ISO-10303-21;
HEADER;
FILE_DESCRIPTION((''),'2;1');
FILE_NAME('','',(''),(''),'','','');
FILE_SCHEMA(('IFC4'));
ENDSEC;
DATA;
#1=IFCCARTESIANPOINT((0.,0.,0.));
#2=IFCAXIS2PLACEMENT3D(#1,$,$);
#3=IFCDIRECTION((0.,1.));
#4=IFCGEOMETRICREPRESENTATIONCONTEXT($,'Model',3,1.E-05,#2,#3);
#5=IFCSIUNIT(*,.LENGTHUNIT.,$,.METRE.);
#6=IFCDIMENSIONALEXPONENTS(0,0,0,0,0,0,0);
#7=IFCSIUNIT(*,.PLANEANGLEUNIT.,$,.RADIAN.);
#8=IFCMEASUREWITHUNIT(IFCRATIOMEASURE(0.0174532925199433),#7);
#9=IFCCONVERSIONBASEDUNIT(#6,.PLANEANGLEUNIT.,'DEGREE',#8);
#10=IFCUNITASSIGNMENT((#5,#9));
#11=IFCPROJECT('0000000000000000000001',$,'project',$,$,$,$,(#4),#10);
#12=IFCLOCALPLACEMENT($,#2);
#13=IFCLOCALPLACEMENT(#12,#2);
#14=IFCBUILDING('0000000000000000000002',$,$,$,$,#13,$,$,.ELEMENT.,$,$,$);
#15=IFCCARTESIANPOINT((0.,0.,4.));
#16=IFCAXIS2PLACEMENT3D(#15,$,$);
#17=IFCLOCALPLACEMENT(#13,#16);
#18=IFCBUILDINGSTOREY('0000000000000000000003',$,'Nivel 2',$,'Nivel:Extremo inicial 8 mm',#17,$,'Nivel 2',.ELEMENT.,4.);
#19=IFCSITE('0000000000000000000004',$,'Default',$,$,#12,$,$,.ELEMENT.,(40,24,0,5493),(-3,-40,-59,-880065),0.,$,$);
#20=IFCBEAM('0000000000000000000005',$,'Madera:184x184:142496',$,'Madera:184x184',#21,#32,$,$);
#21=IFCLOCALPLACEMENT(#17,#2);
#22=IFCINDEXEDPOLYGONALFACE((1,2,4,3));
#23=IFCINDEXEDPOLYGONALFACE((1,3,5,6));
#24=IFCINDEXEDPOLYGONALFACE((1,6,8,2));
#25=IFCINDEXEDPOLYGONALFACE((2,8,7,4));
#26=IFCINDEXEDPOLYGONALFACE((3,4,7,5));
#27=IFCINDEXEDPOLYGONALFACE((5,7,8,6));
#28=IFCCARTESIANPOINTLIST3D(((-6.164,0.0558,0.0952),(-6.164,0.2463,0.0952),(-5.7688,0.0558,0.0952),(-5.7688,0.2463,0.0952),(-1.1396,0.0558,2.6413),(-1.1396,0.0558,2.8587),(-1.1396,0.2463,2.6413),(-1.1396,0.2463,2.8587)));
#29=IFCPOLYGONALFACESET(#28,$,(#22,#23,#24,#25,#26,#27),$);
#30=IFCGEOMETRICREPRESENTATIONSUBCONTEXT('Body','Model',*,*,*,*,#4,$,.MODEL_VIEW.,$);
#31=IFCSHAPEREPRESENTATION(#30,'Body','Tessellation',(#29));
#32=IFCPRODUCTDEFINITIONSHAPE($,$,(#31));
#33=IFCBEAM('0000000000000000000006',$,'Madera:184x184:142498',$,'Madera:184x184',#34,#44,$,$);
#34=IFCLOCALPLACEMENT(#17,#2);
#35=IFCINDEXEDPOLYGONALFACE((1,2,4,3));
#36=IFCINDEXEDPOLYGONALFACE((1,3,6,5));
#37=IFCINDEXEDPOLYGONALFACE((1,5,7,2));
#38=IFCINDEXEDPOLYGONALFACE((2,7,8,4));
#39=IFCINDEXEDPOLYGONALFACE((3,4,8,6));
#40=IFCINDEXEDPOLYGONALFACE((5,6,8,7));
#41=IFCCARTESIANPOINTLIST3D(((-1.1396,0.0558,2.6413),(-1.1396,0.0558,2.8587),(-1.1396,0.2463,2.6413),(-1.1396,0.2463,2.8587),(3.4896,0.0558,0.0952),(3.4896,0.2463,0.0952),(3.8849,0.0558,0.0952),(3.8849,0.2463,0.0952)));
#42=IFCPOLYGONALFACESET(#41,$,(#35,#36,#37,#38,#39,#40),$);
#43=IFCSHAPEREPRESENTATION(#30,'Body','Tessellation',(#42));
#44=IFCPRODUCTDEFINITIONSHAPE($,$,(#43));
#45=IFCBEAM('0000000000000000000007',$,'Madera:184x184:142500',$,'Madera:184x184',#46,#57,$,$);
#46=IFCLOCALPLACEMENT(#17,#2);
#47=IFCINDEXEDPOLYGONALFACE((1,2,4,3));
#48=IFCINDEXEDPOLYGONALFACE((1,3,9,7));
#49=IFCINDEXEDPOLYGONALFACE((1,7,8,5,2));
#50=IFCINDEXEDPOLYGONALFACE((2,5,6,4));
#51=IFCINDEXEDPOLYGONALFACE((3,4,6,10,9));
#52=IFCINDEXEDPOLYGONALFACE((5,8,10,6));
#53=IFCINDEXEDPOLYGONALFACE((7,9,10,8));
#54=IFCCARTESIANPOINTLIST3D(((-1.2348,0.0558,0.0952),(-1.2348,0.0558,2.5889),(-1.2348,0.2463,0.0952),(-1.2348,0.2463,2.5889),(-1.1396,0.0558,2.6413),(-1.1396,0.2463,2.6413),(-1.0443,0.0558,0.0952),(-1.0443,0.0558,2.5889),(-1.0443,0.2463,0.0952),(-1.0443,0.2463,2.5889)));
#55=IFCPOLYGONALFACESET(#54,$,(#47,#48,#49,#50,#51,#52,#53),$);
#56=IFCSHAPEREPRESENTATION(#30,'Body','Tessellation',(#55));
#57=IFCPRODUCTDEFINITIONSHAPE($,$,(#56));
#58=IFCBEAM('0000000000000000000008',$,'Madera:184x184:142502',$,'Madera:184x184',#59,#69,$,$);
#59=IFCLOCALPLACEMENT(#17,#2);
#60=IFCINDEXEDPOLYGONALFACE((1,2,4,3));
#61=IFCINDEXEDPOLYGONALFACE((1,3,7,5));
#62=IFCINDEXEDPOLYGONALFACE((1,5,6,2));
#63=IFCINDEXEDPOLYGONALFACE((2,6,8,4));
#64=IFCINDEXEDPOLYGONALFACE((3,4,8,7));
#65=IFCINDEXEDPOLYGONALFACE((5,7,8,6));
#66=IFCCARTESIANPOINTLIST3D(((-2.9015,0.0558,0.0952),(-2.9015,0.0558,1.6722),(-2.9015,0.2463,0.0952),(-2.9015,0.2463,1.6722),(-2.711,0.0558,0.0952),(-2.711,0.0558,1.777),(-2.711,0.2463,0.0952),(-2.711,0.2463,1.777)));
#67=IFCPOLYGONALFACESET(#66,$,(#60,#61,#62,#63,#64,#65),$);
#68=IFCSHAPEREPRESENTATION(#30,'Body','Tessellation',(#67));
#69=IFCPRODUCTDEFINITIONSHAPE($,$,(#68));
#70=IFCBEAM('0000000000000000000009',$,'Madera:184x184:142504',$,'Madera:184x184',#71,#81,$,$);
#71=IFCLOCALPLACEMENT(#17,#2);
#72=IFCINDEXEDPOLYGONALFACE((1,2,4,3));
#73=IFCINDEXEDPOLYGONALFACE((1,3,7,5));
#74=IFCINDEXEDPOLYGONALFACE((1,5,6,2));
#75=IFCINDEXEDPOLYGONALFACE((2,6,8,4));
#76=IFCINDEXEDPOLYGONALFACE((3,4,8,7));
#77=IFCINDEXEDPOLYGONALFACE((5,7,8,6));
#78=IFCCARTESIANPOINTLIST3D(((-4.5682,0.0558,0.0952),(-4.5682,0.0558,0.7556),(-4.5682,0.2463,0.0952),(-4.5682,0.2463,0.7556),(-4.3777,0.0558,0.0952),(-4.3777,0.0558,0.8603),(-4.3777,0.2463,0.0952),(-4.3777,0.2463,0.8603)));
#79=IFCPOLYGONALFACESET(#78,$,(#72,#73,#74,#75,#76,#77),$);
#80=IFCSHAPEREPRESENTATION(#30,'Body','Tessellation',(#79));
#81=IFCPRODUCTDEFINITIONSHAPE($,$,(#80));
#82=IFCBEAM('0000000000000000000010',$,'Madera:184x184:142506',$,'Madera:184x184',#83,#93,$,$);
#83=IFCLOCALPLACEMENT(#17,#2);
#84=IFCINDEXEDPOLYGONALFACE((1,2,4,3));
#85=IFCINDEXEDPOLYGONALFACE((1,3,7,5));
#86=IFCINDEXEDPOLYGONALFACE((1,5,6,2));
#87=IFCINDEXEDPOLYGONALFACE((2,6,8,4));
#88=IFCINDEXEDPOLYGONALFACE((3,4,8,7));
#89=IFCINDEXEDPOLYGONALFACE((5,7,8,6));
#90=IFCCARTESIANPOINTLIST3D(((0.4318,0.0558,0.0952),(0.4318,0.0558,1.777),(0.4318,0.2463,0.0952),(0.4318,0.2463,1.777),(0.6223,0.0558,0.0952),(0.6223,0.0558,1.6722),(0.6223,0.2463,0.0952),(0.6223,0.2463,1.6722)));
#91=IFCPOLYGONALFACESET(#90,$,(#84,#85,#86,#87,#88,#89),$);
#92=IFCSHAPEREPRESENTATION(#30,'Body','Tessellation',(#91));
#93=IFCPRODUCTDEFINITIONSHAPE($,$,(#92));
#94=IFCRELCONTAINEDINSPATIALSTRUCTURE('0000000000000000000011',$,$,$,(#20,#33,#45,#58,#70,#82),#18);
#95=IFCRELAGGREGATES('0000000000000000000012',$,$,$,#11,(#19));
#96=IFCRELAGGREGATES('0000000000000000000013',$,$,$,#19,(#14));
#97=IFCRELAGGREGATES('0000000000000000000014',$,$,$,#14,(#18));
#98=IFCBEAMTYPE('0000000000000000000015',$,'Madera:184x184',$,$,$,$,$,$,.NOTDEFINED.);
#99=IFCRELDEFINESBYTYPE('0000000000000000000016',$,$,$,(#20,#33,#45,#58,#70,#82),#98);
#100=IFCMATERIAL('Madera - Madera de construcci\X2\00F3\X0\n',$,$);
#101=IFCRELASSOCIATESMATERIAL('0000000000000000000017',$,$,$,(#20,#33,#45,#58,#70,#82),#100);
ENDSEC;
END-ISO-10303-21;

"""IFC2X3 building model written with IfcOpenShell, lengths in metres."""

from ifc_helpers import new_model, entity, si_unit, converted_unit, direction, frame, frame_2d, origin, origin_2d_with_axis, place, context, subcontext, project, spatial, rectangle, extrude, clip, halfspace, material, type_object, element, save


model = new_model("IFC2X3")

# Units and contexts
model_context = context("Model", 3, precision=1e-05, world=origin(), true_north=direction((0.0, 1.0)))
body_context = subcontext(model_context, "Body", "Model", "MODEL_VIEW")
ifc_project = project(units=[si_unit("LENGTHUNIT", "METRE"), converted_unit("PLANEANGLEUNIT", "DEGREE", entity("IfcRatioMeasure", 0.0174532925199433), si_unit("PLANEANGLEUNIT", "RADIAN"), dimensions=[0, 0, 0, 0, 0, 0, 0])], contexts=[model_context])

# Site, building, storey
site_placement = place(None, origin())
site = spatial("IfcSite", under=ifc_project, at=site_placement, Name="Default", CompositionType="ELEMENT", RefLatitude=(40, 24, 0, 5493), RefLongitude=(-3, -40, -59, -880065), RefElevation=0.0)
building_placement = place(site_placement, origin())
building = spatial("IfcBuilding", under=site, at=building_placement, CompositionType="ELEMENT")
storey_placement = place(building_placement, frame((0.0, 0.0, 4.0)))
storey = spatial("IfcBuildingStorey", under=building, at=storey_placement, Name="Nivel 2", ObjectType="Nivel:Extremo inicial 8 mm", LongName="Nivel 2", CompositionType="ELEMENT", Elevation=4.0)

# Beams
ifc_material = material(Name="Madera - Madera de construcción")
beam_type = type_object("IfcBeamType", Name="Madera:184x184", PredefinedType="NOTDEFINED")
beam_1_placement = place(storey_placement, frame((-6.1396, 0.1511, 0.0), z_axis=(-0.481919, 0.0, 0.876216), x_axis=(0.876216, 0.0, 0.481919)))
element("IfcBeam", 1, at=beam_1_placement, inside=storey, type_object=beam_type, material=ifc_material, Name="Madera:184x184:142496", ObjectType="Madera:184x184", context=body_context, shape_type="Clipping", body=[
    clip(clip(extrude(rectangle(XDim=0.1905, YDim=0.1905, at=frame_2d((0.0, 0.0), x_axis=(1.0, 0.0))), frame((0.0245, 0.0, 0.0), z_axis=(1.0, 0.0, 0.0), x_axis=(0.0, 0.0, -1.0)), (0.0, 0.0, 1.0), 5.7343), halfspace(frame((-0.0919, -0.0953, 0.1593), z_axis=(-0.481919, 0.0, -0.876216), x_axis=(0.876216, 0.0, -0.481919)), False)), halfspace(frame((5.7587, 0.0, 0.0952), z_axis=(0.876216, 0.0, -0.481919), x_axis=(0.0, -1.0, 0.0)), False)),
])
beam_2_placement = place(storey_placement, frame((-1.1396, 0.1511, 2.75), z_axis=(0.481919, 0.0, 0.876216), x_axis=(0.876216, 0.0, -0.481919)))
element("IfcBeam", 2, at=beam_2_placement, inside=storey, type_object=beam_type, material=ifc_material, Name="Madera:184x184:142498", ObjectType="Madera:184x184", context=body_context, shape_type="Clipping", body=[
    clip(clip(extrude(rectangle(XDim=0.1905, YDim=0.1905, at=frame_2d((0.0, 0.0), x_axis=(1.0, 0.0))), frame((-0.0524, 0.0, 0.0), z_axis=(1.0, 0.0, 0.0), x_axis=(0.0, 0.0, -1.0)), (0.0, 0.0, 1.0), 5.7343), halfspace(frame((-3.2395, -0.0953, -4.8115), z_axis=(0.481919, 0.0, -0.876216), x_axis=(0.876216, 0.0, 0.481919)), False)), halfspace(frame((-0.0524, 0.0, 0.0952), z_axis=(-0.876216, 0.0, -0.481919), x_axis=(0.0, 1.0, 0.0)), False)),
])
beam_3_placement = place(storey_placement, frame((-1.1396, 0.1511, 0.0), z_axis=(1.0, 0.0, 0.0), x_axis=(0.0, 0.0, 1.0)))
element("IfcBeam", 3, at=beam_3_placement, inside=storey, type_object=beam_type, material=ifc_material, Name="Madera:184x184:142500", ObjectType="Madera:184x184", context=body_context, shape_type="Clipping", body=[
    clip(clip(extrude(rectangle(XDim=0.1905, YDim=0.1905, at=frame_2d((0.0, 0.0), x_axis=(1.0, 0.0))), frame((0.0952, 0.0, 0.0), z_axis=(1.0, 0.0, 0.0), x_axis=(0.0, 1.0, 0.0)), (0.0, 0.0, 1.0), 2.546), halfspace(frame((-0.256, -0.0953, -5.2678), z_axis=(0.876216, 0.0, -0.481919), x_axis=(0.481919, 0.0, 0.876216)), False)), halfspace(frame((2.6665, -0.0952, -0.0457), z_axis=(0.876216, 0.0, 0.481919), x_axis=(-0.481919, 0.0, 0.876216)), False)),
])
beam_4_placement = place(storey_placement, frame((-2.8062, 0.1511, 0.0), z_axis=(1.0, 0.0, 0.0), x_axis=(0.0, 0.0, 1.0)))
element("IfcBeam", 4, at=beam_4_placement, inside=storey, type_object=beam_type, material=ifc_material, Name="Madera:184x184:142502", ObjectType="Madera:184x184", context=body_context, shape_type="Clipping", body=[
    clip(extrude(rectangle(XDim=0.1905, YDim=0.1905, at=frame_2d((0.0, 0.0), x_axis=(1.0, 0.0))), frame((0.0952, 0.0, 0.0), z_axis=(1.0, 0.0, 0.0), x_axis=(0.0, 0.0, -1.0)), (0.0, 0.0, 1.0), 1.6818), halfspace(frame((-0.256, -0.0953, -3.6011), z_axis=(0.876216, 0.0, -0.481919), x_axis=(0.481919, 0.0, 0.876216)), False)),
])
beam_5_placement = place(storey_placement, frame((-4.4729, 0.1511, 0.0), z_axis=(1.0, 0.0, 0.0), x_axis=(0.0, 0.0, 1.0)))
element("IfcBeam", 5, at=beam_5_placement, inside=storey, type_object=beam_type, material=ifc_material, Name="Madera:184x184:142504", ObjectType="Madera:184x184", context=body_context, shape_type="Clipping", body=[
    clip(extrude(rectangle(XDim=0.1905, YDim=0.1905, at=origin_2d_with_axis()), frame((0.0952, 0.0, 0.0), z_axis=(1.0, 0.0, 0.0), x_axis=(0.0, 0.0, -1.0)), (0.0, 0.0, 1.0), 0.7651), halfspace(frame((-0.256, -0.0953, -1.9345), z_axis=(0.876216, 0.0, -0.481919), x_axis=(0.481919, 0.0, 0.876216)), False)),
])
beam_6_placement = place(storey_placement, frame((0.5271, 0.1511, 0.0), z_axis=(1.0, 0.0, 0.0), x_axis=(0.0, 0.0, 1.0)))
element("IfcBeam", 6, at=beam_6_placement, inside=storey, type_object=beam_type, material=ifc_material, Name="Madera:184x184:142506", ObjectType="Madera:184x184", context=body_context, shape_type="Clipping", body=[
    clip(extrude(rectangle(XDim=0.1905, YDim=0.1905, at=origin_2d_with_axis()), frame((0.0952, 0.0, 0.0), z_axis=(1.0, 0.0, 0.0), x_axis=(0.0, 0.0, -1.0)), (0.0, 0.0, 1.0), 1.6818), halfspace(frame((2.6665, -0.0953, -1.7124), z_axis=(0.876216, 0.0, 0.481919), x_axis=(-0.481919, 0.0, 0.876216)), False)),
])

save(model, "model.ifc")
